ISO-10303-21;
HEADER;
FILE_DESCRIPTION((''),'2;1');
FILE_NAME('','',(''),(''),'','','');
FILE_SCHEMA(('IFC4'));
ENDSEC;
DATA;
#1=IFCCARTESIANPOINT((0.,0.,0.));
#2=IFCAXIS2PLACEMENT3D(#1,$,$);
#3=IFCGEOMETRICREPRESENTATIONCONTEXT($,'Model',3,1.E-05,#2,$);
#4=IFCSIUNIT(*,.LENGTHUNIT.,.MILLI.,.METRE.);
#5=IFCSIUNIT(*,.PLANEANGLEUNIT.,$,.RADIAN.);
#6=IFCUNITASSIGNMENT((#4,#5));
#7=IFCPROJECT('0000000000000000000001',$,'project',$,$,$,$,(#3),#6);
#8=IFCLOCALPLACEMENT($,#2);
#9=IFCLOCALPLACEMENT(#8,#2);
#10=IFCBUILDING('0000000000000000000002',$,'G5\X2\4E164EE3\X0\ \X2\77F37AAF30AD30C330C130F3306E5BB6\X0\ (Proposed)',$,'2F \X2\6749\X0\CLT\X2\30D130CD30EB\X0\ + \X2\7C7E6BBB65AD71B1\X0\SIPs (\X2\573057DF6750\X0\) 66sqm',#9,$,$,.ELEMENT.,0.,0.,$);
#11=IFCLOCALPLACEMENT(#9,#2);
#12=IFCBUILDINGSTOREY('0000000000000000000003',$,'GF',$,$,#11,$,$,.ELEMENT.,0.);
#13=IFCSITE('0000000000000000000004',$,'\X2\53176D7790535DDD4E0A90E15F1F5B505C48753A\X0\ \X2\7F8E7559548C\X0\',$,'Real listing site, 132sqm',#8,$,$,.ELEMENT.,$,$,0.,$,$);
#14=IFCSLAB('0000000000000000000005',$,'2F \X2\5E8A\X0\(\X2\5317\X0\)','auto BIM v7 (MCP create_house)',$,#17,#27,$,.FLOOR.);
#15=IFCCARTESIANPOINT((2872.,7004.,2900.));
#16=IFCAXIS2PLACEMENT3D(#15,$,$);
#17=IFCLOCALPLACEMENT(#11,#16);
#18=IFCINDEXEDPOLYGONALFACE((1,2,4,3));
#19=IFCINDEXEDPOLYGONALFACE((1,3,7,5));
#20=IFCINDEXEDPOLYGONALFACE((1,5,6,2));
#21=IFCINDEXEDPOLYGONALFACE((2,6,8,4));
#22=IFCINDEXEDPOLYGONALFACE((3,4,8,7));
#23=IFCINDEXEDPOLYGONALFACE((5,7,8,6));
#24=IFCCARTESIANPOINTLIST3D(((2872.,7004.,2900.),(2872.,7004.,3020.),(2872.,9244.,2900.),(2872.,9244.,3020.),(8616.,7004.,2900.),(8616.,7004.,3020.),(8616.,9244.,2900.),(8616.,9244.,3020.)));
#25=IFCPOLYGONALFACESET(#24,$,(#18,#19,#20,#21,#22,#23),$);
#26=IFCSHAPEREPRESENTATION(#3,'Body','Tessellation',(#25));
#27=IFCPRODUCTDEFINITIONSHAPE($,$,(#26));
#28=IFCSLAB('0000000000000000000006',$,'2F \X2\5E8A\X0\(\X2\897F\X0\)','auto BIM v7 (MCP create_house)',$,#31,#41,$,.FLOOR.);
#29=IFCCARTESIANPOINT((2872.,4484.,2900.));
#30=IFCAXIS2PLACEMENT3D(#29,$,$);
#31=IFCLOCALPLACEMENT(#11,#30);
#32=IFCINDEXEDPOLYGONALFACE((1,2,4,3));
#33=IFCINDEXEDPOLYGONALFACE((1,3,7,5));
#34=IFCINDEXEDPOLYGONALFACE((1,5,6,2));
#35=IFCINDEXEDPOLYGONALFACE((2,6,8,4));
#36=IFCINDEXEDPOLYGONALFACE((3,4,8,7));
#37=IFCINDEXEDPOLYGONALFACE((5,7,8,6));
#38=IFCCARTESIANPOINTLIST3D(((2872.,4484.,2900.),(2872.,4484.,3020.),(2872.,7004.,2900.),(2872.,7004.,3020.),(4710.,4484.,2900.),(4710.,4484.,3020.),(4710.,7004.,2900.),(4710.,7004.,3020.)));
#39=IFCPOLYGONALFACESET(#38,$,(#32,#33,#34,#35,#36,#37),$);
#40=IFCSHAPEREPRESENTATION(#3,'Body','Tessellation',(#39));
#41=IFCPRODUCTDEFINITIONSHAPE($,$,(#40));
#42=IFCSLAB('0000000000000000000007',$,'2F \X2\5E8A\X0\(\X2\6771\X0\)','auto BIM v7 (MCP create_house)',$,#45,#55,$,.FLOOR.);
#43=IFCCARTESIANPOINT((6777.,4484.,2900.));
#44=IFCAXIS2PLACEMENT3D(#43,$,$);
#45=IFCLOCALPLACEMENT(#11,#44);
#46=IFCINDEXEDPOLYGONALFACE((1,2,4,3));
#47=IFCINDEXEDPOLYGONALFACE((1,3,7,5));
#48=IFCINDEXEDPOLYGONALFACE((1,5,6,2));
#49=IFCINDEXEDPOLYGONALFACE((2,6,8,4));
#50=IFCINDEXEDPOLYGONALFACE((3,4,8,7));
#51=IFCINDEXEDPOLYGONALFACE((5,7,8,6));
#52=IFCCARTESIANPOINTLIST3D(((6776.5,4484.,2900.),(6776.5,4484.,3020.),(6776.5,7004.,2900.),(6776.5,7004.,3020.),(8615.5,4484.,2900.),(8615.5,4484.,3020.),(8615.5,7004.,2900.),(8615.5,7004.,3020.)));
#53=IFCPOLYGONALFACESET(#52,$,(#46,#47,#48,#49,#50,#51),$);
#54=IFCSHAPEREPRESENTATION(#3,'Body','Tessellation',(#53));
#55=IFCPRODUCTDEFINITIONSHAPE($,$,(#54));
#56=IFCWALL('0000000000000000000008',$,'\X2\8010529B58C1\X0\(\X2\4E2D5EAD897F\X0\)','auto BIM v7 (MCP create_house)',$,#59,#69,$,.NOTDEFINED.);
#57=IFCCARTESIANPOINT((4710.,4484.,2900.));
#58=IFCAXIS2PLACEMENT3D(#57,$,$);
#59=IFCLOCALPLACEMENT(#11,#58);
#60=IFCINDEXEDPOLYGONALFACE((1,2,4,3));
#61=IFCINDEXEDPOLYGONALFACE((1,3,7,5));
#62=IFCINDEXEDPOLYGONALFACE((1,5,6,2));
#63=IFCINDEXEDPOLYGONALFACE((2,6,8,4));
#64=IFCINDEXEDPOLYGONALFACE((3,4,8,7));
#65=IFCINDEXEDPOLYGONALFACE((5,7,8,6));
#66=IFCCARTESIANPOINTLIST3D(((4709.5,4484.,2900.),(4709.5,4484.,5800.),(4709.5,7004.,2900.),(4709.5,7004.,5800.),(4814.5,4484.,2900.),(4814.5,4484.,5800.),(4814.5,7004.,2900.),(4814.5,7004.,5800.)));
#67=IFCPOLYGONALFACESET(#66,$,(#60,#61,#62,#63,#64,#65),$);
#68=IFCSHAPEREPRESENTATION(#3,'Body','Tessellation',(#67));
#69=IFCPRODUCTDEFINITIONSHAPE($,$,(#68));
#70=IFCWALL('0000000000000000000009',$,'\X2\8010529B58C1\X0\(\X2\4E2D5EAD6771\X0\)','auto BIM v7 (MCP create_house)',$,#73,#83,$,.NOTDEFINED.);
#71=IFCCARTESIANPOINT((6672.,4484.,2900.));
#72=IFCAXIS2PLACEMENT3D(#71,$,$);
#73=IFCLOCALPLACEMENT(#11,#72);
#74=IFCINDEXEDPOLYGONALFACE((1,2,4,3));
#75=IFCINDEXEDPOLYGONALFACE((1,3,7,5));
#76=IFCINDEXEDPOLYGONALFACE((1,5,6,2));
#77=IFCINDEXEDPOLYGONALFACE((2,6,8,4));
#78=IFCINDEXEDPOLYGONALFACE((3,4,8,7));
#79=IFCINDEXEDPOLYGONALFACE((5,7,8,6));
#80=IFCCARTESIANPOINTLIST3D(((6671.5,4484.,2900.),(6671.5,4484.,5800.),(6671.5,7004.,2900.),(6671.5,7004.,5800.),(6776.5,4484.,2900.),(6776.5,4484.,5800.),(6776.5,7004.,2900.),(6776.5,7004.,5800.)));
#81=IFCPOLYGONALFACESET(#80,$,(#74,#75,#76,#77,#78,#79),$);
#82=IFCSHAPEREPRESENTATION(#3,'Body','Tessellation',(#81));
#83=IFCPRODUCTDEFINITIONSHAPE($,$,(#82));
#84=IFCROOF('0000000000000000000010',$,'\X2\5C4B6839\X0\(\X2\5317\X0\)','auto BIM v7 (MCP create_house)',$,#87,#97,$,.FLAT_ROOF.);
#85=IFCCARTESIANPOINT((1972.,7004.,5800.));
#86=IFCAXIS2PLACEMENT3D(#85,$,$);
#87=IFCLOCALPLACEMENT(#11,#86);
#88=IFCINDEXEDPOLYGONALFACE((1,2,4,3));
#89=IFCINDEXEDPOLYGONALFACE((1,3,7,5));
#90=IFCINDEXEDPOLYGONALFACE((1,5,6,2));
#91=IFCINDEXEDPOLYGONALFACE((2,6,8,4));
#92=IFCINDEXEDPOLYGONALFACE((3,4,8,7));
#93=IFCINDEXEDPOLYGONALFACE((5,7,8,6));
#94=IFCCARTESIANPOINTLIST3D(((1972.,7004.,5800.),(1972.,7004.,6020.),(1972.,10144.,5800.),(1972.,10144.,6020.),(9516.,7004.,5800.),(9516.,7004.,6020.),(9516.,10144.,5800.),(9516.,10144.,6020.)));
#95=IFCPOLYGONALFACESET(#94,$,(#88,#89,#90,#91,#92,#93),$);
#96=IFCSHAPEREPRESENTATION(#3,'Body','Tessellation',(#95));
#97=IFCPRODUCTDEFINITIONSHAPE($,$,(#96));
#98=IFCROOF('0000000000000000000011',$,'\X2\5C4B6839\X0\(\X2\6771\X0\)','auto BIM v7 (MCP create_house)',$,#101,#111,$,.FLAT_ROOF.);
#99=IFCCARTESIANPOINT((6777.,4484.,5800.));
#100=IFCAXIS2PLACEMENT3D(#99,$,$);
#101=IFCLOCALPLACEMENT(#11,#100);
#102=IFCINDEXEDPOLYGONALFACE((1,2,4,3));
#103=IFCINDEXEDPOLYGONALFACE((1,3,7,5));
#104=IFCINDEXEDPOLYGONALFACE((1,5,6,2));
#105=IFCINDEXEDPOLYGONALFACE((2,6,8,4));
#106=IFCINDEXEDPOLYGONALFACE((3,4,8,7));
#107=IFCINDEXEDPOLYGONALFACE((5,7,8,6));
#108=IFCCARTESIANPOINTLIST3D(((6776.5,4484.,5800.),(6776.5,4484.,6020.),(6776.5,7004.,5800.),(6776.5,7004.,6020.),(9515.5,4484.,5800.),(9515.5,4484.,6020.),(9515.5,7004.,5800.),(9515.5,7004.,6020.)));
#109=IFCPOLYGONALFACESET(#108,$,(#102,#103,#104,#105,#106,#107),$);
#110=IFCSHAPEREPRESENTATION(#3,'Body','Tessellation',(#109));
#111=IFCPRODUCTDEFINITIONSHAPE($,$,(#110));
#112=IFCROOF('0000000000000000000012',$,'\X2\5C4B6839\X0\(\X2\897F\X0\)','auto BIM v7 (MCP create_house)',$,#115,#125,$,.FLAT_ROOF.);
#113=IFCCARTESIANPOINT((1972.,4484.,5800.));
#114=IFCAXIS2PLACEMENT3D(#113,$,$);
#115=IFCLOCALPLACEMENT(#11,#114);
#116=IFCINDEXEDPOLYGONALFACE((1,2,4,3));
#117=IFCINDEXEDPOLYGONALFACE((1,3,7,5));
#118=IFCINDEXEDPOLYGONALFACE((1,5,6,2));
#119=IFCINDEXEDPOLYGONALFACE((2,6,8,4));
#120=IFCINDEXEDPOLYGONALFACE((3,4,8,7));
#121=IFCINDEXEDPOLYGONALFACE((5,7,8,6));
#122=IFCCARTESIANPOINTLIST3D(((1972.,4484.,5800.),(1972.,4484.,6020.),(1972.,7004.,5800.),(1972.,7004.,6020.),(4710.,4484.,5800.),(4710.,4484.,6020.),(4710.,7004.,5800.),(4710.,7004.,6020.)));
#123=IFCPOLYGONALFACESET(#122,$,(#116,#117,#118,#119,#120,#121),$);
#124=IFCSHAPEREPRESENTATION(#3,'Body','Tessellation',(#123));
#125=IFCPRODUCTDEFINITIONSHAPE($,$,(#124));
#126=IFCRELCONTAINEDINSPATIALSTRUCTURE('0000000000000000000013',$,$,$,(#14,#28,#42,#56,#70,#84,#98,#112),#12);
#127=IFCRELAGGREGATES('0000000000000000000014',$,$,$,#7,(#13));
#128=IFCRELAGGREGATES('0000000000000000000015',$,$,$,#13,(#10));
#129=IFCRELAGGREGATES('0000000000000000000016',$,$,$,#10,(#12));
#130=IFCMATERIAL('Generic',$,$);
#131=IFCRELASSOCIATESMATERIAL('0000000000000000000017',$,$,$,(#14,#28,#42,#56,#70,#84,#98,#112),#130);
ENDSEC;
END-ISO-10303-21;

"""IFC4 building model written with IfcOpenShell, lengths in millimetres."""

from ifc_helpers import new_model, si_unit, frame, frame_2d, origin, place, context, project, spatial, rectangle, extrude, material, element, save


model = new_model("IFC4")

# Units and contexts
model_context = context("Model", 3, precision=1e-05, world=origin())
ifc_project = project(units=[si_unit("LENGTHUNIT", "METRE", prefix="MILLI"), si_unit("PLANEANGLEUNIT", "RADIAN")], contexts=[model_context])

# Site, building, storey
site_placement = place(None, origin())
site = spatial("IfcSite", under=ifc_project, at=site_placement, Name="北海道川上郡弟子屈町 美留和", ObjectType="Real listing site, 132sqm", CompositionType="ELEMENT", RefElevation=0.0)
building_placement = place(site_placement, origin())
building = spatial("IfcBuilding", under=site, at=building_placement, Name="G5世代 石窯キッチンの家 (Proposed)", ObjectType="2F 杉CLTパネル + 籾殻断熱SIPs (地域材) 66sqm", CompositionType="ELEMENT", ElevationOfRefHeight=0.0, ElevationOfTerrain=0.0)
storey_placement = place(building_placement, origin())
storey = spatial("IfcBuildingStorey", under=building, at=storey_placement, Name="GF", CompositionType="ELEMENT", Elevation=0.0)

# Slabs
ifc_material = material(Name="Generic")
slab_1_placement = place(storey_placement, frame((2872.0, 7004.0, 2900.0)))
element("IfcSlab", 1, at=slab_1_placement, inside=storey, material=ifc_material, Name="2F 床(北)", Description="auto BIM v7 (MCP create_house)", PredefinedType="FLOOR", context=model_context, shape_type="SweptSolid", body=[
    extrude(rectangle(XDim=5744.0, YDim=2240.0, at=frame_2d((2872.0, 1120.0))), frame((2872.0, 7004.0, 2900.0)), (0.0, 0.0, 1.0), 120.0),
])
slab_2_placement = place(storey_placement, frame((2872.0, 4484.0, 2900.0)))
element("IfcSlab", 2, at=slab_2_placement, inside=storey, material=ifc_material, Name="2F 床(西)", Description="auto BIM v7 (MCP create_house)", PredefinedType="FLOOR", context=model_context, shape_type="SweptSolid", body=[
    extrude(rectangle(XDim=1838.0, YDim=2520.0, at=frame_2d((919.0, 1260.0))), frame((2872.0, 4484.0, 2900.0)), (0.0, 0.0, 1.0), 120.0),
])
slab_3_placement = place(storey_placement, frame((6777.0, 4484.0, 2900.0)))
element("IfcSlab", 3, at=slab_3_placement, inside=storey, material=ifc_material, Name="2F 床(東)", Description="auto BIM v7 (MCP create_house)", PredefinedType="FLOOR", context=model_context, shape_type="SweptSolid", body=[
    extrude(rectangle(XDim=1839.0, YDim=2520.0, at=frame_2d((919.0, 1260.0))), frame((6777.0, 4484.0, 2900.0)), (0.0, 0.0, 1.0), 120.0),
])

# Walls
wall_1_placement = place(storey_placement, frame((4710.0, 4484.0, 2900.0)))
element("IfcWall", 4, at=wall_1_placement, inside=storey, material=ifc_material, Name="耐力壁(中庭西)", Description="auto BIM v7 (MCP create_house)", PredefinedType="NOTDEFINED", context=model_context, shape_type="SweptSolid", body=[
    extrude(rectangle(XDim=105.0, YDim=2520.0, at=frame_2d((52.0, 1260.0))), frame((4710.0, 4484.0, 2900.0)), (0.0, 0.0, 1.0), 2900.0),
])
wall_2_placement = place(storey_placement, frame((6672.0, 4484.0, 2900.0)))
element("IfcWall", 5, at=wall_2_placement, inside=storey, material=ifc_material, Name="耐力壁(中庭東)", Description="auto BIM v7 (MCP create_house)", PredefinedType="NOTDEFINED", context=model_context, shape_type="SweptSolid", body=[
    extrude(rectangle(XDim=105.0, YDim=2520.0, at=frame_2d((52.0, 1260.0))), frame((6672.0, 4484.0, 2900.0)), (0.0, 0.0, 1.0), 2900.0),
])

# Roofs
roof_1_placement = place(storey_placement, frame((1972.0, 7004.0, 5800.0)))
element("IfcRoof", 6, at=roof_1_placement, inside=storey, material=ifc_material, Name="屋根(北)", Description="auto BIM v7 (MCP create_house)", PredefinedType="FLAT_ROOF", context=model_context, shape_type="SweptSolid", body=[
    extrude(rectangle(XDim=7544.0, YDim=3140.0, at=frame_2d((3772.0, 1570.0))), frame((1972.0, 7004.0, 5800.0)), (0.0, 0.0, 1.0), 220.0),
])
roof_2_placement = place(storey_placement, frame((6777.0, 4484.0, 5800.0)))
element("IfcRoof", 7, at=roof_2_placement, inside=storey, material=ifc_material, Name="屋根(東)", Description="auto BIM v7 (MCP create_house)", PredefinedType="FLAT_ROOF", context=model_context, shape_type="SweptSolid", body=[
    extrude(rectangle(XDim=2739.0, YDim=2520.0, at=frame_2d((1369.0, 1260.0))), frame((6777.0, 4484.0, 5800.0)), (0.0, 0.0, 1.0), 220.0),
])
roof_3_placement = place(storey_placement, frame((1972.0, 4484.0, 5800.0)))
element("IfcRoof", 8, at=roof_3_placement, inside=storey, material=ifc_material, Name="屋根(西)", Description="auto BIM v7 (MCP create_house)", PredefinedType="FLAT_ROOF", context=model_context, shape_type="SweptSolid", body=[
    extrude(rectangle(XDim=2738.0, YDim=2520.0, at=frame_2d((1369.0, 1260.0))), frame((1972.0, 4484.0, 5800.0)), (0.0, 0.0, 1.0), 220.0),
])

save(model, "model.ifc")
